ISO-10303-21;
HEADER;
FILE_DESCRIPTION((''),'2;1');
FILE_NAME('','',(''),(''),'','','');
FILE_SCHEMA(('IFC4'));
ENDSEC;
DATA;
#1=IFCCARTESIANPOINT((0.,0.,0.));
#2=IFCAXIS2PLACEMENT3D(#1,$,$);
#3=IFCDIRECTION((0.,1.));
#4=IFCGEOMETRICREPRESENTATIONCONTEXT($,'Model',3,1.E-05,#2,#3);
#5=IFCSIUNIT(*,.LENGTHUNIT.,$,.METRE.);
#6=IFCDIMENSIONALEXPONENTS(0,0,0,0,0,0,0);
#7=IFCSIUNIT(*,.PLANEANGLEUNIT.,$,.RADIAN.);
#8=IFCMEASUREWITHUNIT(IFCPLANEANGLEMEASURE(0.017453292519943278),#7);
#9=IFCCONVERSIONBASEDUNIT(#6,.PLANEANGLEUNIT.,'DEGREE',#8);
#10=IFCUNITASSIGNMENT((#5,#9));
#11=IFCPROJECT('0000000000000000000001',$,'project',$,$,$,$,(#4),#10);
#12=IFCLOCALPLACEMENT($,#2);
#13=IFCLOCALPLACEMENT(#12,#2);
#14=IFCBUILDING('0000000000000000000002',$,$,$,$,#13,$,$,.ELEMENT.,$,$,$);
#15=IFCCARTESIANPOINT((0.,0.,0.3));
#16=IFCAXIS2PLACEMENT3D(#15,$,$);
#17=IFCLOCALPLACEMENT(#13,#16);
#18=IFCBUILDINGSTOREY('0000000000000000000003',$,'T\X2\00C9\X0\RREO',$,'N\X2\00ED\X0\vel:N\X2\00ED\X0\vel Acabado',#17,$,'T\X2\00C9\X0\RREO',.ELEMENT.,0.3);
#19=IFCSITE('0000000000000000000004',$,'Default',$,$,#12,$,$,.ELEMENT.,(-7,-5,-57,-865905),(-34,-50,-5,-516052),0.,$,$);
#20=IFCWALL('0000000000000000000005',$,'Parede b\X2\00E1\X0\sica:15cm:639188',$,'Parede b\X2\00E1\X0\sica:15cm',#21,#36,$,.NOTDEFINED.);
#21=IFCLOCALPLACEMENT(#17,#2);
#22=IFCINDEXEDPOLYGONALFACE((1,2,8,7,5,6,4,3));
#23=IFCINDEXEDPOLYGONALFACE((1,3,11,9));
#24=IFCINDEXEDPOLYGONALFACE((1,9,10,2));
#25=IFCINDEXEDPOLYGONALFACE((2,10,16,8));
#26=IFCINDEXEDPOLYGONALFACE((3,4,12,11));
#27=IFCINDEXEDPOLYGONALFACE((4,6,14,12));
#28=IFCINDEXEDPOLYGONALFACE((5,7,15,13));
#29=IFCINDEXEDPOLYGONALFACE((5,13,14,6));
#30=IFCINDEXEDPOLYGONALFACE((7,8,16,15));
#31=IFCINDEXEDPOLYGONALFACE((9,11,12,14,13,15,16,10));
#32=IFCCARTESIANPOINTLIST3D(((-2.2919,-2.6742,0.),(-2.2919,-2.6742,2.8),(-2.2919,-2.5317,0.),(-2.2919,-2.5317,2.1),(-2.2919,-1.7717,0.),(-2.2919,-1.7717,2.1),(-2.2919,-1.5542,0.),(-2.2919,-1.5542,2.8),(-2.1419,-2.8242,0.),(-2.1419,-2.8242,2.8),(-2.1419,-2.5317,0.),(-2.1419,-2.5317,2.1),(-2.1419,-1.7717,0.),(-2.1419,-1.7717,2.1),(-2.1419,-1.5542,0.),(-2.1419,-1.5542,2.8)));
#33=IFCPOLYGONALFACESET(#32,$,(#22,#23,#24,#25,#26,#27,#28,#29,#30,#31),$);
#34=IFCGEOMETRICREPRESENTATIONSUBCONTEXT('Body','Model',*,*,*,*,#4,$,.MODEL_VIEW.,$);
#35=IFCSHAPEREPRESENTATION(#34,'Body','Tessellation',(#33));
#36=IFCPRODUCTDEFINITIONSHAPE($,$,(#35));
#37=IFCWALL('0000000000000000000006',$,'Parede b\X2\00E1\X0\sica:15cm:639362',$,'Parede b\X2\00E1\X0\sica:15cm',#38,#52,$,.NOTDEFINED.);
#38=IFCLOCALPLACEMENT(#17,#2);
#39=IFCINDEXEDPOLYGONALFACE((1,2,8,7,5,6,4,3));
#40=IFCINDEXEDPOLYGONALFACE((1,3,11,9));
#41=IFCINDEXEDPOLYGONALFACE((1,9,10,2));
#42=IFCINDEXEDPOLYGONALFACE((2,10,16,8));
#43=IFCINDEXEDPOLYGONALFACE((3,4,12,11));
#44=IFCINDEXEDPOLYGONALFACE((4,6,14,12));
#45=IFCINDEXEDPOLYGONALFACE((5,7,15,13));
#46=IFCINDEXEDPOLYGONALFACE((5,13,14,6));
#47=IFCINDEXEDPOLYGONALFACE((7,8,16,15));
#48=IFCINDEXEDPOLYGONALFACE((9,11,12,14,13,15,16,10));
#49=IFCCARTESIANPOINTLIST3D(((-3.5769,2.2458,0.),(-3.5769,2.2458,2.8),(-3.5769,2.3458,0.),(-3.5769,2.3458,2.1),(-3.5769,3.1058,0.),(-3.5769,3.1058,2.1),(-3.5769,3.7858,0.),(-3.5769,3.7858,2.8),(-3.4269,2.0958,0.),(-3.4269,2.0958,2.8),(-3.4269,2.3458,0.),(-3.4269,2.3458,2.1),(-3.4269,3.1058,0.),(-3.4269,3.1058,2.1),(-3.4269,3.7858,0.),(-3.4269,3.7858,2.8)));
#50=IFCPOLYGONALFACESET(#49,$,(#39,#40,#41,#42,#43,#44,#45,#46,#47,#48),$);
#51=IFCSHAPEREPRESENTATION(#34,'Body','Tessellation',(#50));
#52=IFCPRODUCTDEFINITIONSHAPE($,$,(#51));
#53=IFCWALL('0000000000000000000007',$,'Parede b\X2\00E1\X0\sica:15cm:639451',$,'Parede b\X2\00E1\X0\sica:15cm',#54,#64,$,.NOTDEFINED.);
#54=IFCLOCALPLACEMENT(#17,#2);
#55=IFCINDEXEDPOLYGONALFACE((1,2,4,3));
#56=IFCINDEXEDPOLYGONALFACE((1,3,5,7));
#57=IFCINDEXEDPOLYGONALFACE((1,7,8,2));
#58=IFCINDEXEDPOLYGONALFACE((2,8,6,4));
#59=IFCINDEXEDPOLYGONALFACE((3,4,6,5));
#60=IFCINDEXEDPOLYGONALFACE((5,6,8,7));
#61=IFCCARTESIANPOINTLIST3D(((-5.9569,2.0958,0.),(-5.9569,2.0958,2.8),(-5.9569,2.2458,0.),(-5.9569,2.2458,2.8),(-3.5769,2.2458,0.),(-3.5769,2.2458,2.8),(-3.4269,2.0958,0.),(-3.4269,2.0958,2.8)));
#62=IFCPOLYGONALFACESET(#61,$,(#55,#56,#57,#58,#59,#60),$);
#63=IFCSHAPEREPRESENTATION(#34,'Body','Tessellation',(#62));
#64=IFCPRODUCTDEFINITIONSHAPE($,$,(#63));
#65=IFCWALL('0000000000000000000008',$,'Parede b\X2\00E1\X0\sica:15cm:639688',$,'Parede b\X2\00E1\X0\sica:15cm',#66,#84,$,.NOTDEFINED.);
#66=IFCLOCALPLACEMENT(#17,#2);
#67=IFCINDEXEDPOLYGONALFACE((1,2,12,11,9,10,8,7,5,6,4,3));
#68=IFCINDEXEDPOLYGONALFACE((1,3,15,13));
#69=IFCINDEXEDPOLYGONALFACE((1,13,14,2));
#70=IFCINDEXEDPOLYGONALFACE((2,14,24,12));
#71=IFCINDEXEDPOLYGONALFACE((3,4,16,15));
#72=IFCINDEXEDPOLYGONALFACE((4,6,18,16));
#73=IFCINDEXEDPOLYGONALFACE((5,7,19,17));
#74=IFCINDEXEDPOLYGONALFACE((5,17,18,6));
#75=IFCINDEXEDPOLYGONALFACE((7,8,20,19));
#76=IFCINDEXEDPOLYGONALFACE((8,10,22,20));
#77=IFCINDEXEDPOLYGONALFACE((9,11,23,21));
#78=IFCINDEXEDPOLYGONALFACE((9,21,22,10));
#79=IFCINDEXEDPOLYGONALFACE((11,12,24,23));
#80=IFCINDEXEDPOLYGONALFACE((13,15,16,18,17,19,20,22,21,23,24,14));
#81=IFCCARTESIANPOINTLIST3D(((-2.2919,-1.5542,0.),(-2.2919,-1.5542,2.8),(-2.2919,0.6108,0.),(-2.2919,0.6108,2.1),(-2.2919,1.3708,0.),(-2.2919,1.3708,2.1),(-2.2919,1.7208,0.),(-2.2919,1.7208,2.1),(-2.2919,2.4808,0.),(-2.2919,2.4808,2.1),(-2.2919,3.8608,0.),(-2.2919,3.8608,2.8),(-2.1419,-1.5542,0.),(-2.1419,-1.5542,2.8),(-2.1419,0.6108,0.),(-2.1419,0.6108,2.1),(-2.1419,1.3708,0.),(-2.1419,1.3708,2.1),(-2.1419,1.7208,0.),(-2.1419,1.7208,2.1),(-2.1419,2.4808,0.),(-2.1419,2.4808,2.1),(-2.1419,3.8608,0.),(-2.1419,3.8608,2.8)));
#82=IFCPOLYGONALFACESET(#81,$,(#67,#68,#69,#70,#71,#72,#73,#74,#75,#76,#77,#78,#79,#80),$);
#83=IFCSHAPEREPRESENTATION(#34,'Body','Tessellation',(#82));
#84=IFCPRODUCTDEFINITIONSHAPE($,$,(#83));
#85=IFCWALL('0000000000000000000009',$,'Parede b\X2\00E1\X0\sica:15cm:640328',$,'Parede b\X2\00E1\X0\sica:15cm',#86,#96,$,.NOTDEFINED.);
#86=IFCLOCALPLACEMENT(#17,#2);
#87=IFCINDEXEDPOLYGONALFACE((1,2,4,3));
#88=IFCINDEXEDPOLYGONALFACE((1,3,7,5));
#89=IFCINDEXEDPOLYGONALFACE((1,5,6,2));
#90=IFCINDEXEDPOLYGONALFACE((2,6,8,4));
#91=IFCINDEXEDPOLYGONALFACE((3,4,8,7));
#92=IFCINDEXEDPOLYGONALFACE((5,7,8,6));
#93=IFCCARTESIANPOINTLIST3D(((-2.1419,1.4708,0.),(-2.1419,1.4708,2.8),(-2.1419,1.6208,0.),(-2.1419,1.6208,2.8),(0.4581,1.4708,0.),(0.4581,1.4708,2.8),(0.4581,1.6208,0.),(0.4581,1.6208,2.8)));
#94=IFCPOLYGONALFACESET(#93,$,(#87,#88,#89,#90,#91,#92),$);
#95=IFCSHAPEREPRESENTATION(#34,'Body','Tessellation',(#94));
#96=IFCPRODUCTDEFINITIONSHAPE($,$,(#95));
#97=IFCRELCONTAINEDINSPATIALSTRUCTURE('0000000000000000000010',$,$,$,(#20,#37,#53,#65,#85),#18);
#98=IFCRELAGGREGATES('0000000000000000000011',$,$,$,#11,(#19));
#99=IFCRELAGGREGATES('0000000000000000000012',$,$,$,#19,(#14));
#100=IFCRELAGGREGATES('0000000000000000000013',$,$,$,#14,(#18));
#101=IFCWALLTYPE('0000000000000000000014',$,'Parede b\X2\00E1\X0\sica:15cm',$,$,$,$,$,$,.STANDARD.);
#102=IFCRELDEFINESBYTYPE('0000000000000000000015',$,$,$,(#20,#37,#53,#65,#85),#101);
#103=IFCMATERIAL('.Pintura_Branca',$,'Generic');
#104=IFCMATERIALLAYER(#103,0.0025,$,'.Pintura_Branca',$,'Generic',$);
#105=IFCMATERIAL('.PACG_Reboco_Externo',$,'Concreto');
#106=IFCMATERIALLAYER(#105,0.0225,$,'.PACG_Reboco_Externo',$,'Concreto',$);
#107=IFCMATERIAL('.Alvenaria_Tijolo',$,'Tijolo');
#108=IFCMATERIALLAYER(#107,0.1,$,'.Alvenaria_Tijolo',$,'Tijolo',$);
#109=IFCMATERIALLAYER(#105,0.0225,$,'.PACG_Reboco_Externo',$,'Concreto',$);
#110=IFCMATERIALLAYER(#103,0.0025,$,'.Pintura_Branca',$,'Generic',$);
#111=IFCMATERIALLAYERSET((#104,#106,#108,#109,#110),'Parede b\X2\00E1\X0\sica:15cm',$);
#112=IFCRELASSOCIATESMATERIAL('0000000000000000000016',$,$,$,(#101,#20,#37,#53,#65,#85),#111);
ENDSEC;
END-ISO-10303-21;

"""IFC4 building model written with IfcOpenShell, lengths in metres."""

from ifc_helpers import new_model, entity, si_unit, converted_unit, direction, frame, frame_2d, origin, place, context, subcontext, project, spatial, polyline, rectangle, outline, extrude, material, layer, layer_set, layer_usage, type_object, element, save


model = new_model("IFC4")

# Units and contexts
model_context = context("Model", 3, precision=1e-05, world=origin(), true_north=direction((0.0, 1.0)))
body_context = subcontext(model_context, "Body", "Model", "MODEL_VIEW")
ifc_project = project(units=[si_unit("LENGTHUNIT", "METRE"), converted_unit("PLANEANGLEUNIT", "DEGREE", entity("IfcPlaneAngleMeasure", 0.017453292519943278), si_unit("PLANEANGLEUNIT", "RADIAN"), dimensions=[0, 0, 0, 0, 0, 0, 0])], contexts=[model_context])

# Site, building, storey
site_placement = place(None, origin())
site = spatial("IfcSite", under=ifc_project, at=site_placement, Name="Default", CompositionType="ELEMENT", RefLatitude=(-7, -5, -57, -865905), RefLongitude=(-34, -50, -5, -516052), RefElevation=0.0)
building_placement = place(site_placement, origin())
building = spatial("IfcBuilding", under=site, at=building_placement, CompositionType="ELEMENT")
storey_placement = place(building_placement, frame((0.0, 0.0, 0.3)))
storey = spatial("IfcBuildingStorey", under=building, at=storey_placement, Name="TÉRREO", ObjectType="Nível:Nível Acabado", LongName="TÉRREO", CompositionType="ELEMENT", Elevation=0.3)

# Shared definitions
ifc_material_1 = material(Name=".Pintura_Branca", Category="Generic")
ifc_layer_1 = layer(ifc_material_1, 0.0025, Name=".Pintura_Branca", Category="Generic")
ifc_material_2 = material(Name=".PACG_Reboco_Externo", Category="Concreto")
ifc_layer_2 = layer(ifc_material_2, 0.0225, Name=".PACG_Reboco_Externo", Category="Concreto")
ifc_material_3 = material(Name=".Alvenaria_Tijolo", Category="Tijolo")
ifc_layer_3 = layer(ifc_material_3, 0.1, Name=".Alvenaria_Tijolo", Category="Tijolo")
ifc_layer_4 = layer(ifc_material_2, 0.0225, Name=".PACG_Reboco_Externo", Category="Concreto")
ifc_layer_5 = layer(ifc_material_1, 0.0025, Name=".Pintura_Branca", Category="Generic")
ifc_layer_set_1 = layer_set([ifc_layer_1, ifc_layer_2, ifc_layer_3, ifc_layer_4, ifc_layer_5], Name="Parede básica:15cm")
wall_type = type_object("IfcWallType", Name="Parede básica:15cm", PredefinedType="STANDARD", material=ifc_layer_set_1)

# Walls, openings
ifc_layer_usage_1 = layer_usage(ifc_layer_set_1, "AXIS2", "NEGATIVE", 0.075)
wall_1_placement = place(storey_placement, frame((-2.2169, -1.5542, 0.0), z_axis=(0.0, 0.0, 1.0), x_axis=(0.0, -1.0, 0.0)))
wall_1 = element("IfcWall", 1, at=wall_1_placement, inside=storey, type_object=wall_type, material=ifc_layer_usage_1, Name="Parede básica:15cm:639188", ObjectType="Parede básica:15cm", PredefinedType="NOTDEFINED", context=body_context, shape_type="SweptSolid", body=[
    extrude(outline(polyline([(0.0, -0.075), (1.12, -0.075), (1.27, 0.075), (0.075, 0.075), (0.0, 0.075), (0.0, -0.075)])), origin(), (0.0, 0.0, 1.0), 2.8),
])
opening_1_placement = place(wall_1_placement, frame((0.9775, 0.075, 0.0)))
element("IfcOpeningElement", 2, at=opening_1_placement, cuts=wall_1, PredefinedType="OPENING", context=body_context, shape_type="SweptSolid", body=[
    extrude(rectangle(XDim=0.76, YDim=2.1, at=frame_2d((1.05, 0.38), x_axis=(0.0, 1.0))), frame((0.0, 0.0, 0.0), z_axis=(0.0, -1.0, 0.0), x_axis=(0.0, 0.0, 1.0)), (0.0, 0.0, 1.0), 0.15),
])
ifc_layer_usage_2 = layer_usage(ifc_layer_set_1, "AXIS2", "NEGATIVE", 0.075)
wall_2_placement = place(storey_placement, frame((-3.5019, 3.7858, 0.0), z_axis=(0.0, 0.0, 1.0), x_axis=(0.0, -1.0, 0.0)))
wall_2 = element("IfcWall", 3, at=wall_2_placement, inside=storey, type_object=wall_type, material=ifc_layer_usage_2, Name="Parede básica:15cm:639362", ObjectType="Parede básica:15cm", PredefinedType="NOTDEFINED", context=body_context, shape_type="SweptSolid", body=[
    extrude(outline(polyline([(0.0, -0.075), (1.54, -0.075), (1.69, 0.075), (0.0, 0.075), (0.0, -0.075)])), origin(), (0.0, 0.0, 1.0), 2.8),
])
opening_2_placement = place(wall_2_placement, frame((1.44, 0.075, 0.0)))
element("IfcOpeningElement", 4, at=opening_2_placement, cuts=wall_2, PredefinedType="OPENING", context=body_context, shape_type="SweptSolid", body=[
    extrude(rectangle(XDim=0.76, YDim=2.1, at=frame_2d((1.05, 0.38), x_axis=(0.0, -1.0))), frame((0.0, 0.0, 0.0), z_axis=(0.0, -1.0, 0.0), x_axis=(0.0, 0.0, 1.0)), (0.0, 0.0, 1.0), 0.15),
])

# Wall
ifc_layer_usage_3 = layer_usage(ifc_layer_set_1, "AXIS2", "NEGATIVE", 0.075)
wall_3_placement = place(storey_placement, frame((-3.4269, 2.1708, 0.0), z_axis=(0.0, 0.0, 1.0), x_axis=(-1.0, 0.0, 0.0)))
element("IfcWall", 5, at=wall_3_placement, inside=storey, type_object=wall_type, material=ifc_layer_usage_3, Name="Parede básica:15cm:639451", ObjectType="Parede básica:15cm", PredefinedType="NOTDEFINED", context=body_context, shape_type="SweptSolid", body=[
    extrude(outline(polyline([(2.53, -0.075), (2.53, 0.075), (0.0, 0.075), (0.15, -0.075), (2.53, -0.075)])), origin(), (0.0, 0.0, 1.0), 2.8),
])

# Wall, openings
ifc_layer_usage_4 = layer_usage(ifc_layer_set_1, "AXIS2", "NEGATIVE", 0.075)
wall_4_placement = place(storey_placement, frame((-2.2169, 3.8608, 0.0), z_axis=(0.0, 0.0, 1.0), x_axis=(0.0, -1.0, 0.0)))
wall_4 = element("IfcWall", 6, at=wall_4_placement, inside=storey, type_object=wall_type, material=ifc_layer_usage_4, Name="Parede básica:15cm:639688", ObjectType="Parede básica:15cm", PredefinedType="NOTDEFINED", context=body_context, shape_type="SweptSolid", body=[
    extrude(rectangle(XDim=5.415, YDim=0.15, at=frame_2d((2.7075, 0.0), x_axis=(1.0, 0.0))), origin(), (0.0, 0.0, 1.0), 2.8),
])
opening_3_placement = place(wall_4_placement, frame((1.38, -0.075, 0.0)))
element("IfcOpeningElement", 7, at=opening_3_placement, cuts=wall_4, PredefinedType="OPENING", context=body_context, shape_type="SweptSolid", body=[
    extrude(rectangle(XDim=0.76, YDim=2.1, at=frame_2d((1.05, 0.38), x_axis=(0.0, 1.0))), frame((0.0, 0.0, 0.0), z_axis=(0.0, 1.0, 0.0), x_axis=(0.0, 0.0, 1.0)), (0.0, 0.0, 1.0), 0.15),
])
opening_4_placement = place(wall_4_placement, frame((2.49, -0.075, 0.0)))
element("IfcOpeningElement", 8, at=opening_4_placement, cuts=wall_4, PredefinedType="OPENING", context=body_context, shape_type="SweptSolid", body=[
    extrude(rectangle(XDim=0.76, YDim=2.1, at=frame_2d((1.05, 0.38), x_axis=(0.0, -1.0))), frame((0.0, 0.0, 0.0), z_axis=(0.0, 1.0, 0.0), x_axis=(0.0, 0.0, 1.0)), (0.0, 0.0, 1.0), 0.15),
])

# Wall
ifc_layer_usage_5 = layer_usage(ifc_layer_set_1, "AXIS2", "NEGATIVE", 0.075)
wall_5_placement = place(storey_placement, frame((0.4581, 1.5458, 0.0), z_axis=(0.0, 0.0, 1.0), x_axis=(-1.0, 0.0, 0.0)))
element("IfcWall", 9, at=wall_5_placement, inside=storey, type_object=wall_type, material=ifc_layer_usage_5, Name="Parede básica:15cm:640328", ObjectType="Parede básica:15cm", PredefinedType="NOTDEFINED", context=body_context, shape_type="SweptSolid", body=[
    extrude(rectangle(XDim=2.6, YDim=0.15, at=frame_2d((1.3, 0.0), x_axis=(-1.0, 0.0))), origin(), (0.0, 0.0, 1.0), 2.8),
])

save(model, "model.ifc")
